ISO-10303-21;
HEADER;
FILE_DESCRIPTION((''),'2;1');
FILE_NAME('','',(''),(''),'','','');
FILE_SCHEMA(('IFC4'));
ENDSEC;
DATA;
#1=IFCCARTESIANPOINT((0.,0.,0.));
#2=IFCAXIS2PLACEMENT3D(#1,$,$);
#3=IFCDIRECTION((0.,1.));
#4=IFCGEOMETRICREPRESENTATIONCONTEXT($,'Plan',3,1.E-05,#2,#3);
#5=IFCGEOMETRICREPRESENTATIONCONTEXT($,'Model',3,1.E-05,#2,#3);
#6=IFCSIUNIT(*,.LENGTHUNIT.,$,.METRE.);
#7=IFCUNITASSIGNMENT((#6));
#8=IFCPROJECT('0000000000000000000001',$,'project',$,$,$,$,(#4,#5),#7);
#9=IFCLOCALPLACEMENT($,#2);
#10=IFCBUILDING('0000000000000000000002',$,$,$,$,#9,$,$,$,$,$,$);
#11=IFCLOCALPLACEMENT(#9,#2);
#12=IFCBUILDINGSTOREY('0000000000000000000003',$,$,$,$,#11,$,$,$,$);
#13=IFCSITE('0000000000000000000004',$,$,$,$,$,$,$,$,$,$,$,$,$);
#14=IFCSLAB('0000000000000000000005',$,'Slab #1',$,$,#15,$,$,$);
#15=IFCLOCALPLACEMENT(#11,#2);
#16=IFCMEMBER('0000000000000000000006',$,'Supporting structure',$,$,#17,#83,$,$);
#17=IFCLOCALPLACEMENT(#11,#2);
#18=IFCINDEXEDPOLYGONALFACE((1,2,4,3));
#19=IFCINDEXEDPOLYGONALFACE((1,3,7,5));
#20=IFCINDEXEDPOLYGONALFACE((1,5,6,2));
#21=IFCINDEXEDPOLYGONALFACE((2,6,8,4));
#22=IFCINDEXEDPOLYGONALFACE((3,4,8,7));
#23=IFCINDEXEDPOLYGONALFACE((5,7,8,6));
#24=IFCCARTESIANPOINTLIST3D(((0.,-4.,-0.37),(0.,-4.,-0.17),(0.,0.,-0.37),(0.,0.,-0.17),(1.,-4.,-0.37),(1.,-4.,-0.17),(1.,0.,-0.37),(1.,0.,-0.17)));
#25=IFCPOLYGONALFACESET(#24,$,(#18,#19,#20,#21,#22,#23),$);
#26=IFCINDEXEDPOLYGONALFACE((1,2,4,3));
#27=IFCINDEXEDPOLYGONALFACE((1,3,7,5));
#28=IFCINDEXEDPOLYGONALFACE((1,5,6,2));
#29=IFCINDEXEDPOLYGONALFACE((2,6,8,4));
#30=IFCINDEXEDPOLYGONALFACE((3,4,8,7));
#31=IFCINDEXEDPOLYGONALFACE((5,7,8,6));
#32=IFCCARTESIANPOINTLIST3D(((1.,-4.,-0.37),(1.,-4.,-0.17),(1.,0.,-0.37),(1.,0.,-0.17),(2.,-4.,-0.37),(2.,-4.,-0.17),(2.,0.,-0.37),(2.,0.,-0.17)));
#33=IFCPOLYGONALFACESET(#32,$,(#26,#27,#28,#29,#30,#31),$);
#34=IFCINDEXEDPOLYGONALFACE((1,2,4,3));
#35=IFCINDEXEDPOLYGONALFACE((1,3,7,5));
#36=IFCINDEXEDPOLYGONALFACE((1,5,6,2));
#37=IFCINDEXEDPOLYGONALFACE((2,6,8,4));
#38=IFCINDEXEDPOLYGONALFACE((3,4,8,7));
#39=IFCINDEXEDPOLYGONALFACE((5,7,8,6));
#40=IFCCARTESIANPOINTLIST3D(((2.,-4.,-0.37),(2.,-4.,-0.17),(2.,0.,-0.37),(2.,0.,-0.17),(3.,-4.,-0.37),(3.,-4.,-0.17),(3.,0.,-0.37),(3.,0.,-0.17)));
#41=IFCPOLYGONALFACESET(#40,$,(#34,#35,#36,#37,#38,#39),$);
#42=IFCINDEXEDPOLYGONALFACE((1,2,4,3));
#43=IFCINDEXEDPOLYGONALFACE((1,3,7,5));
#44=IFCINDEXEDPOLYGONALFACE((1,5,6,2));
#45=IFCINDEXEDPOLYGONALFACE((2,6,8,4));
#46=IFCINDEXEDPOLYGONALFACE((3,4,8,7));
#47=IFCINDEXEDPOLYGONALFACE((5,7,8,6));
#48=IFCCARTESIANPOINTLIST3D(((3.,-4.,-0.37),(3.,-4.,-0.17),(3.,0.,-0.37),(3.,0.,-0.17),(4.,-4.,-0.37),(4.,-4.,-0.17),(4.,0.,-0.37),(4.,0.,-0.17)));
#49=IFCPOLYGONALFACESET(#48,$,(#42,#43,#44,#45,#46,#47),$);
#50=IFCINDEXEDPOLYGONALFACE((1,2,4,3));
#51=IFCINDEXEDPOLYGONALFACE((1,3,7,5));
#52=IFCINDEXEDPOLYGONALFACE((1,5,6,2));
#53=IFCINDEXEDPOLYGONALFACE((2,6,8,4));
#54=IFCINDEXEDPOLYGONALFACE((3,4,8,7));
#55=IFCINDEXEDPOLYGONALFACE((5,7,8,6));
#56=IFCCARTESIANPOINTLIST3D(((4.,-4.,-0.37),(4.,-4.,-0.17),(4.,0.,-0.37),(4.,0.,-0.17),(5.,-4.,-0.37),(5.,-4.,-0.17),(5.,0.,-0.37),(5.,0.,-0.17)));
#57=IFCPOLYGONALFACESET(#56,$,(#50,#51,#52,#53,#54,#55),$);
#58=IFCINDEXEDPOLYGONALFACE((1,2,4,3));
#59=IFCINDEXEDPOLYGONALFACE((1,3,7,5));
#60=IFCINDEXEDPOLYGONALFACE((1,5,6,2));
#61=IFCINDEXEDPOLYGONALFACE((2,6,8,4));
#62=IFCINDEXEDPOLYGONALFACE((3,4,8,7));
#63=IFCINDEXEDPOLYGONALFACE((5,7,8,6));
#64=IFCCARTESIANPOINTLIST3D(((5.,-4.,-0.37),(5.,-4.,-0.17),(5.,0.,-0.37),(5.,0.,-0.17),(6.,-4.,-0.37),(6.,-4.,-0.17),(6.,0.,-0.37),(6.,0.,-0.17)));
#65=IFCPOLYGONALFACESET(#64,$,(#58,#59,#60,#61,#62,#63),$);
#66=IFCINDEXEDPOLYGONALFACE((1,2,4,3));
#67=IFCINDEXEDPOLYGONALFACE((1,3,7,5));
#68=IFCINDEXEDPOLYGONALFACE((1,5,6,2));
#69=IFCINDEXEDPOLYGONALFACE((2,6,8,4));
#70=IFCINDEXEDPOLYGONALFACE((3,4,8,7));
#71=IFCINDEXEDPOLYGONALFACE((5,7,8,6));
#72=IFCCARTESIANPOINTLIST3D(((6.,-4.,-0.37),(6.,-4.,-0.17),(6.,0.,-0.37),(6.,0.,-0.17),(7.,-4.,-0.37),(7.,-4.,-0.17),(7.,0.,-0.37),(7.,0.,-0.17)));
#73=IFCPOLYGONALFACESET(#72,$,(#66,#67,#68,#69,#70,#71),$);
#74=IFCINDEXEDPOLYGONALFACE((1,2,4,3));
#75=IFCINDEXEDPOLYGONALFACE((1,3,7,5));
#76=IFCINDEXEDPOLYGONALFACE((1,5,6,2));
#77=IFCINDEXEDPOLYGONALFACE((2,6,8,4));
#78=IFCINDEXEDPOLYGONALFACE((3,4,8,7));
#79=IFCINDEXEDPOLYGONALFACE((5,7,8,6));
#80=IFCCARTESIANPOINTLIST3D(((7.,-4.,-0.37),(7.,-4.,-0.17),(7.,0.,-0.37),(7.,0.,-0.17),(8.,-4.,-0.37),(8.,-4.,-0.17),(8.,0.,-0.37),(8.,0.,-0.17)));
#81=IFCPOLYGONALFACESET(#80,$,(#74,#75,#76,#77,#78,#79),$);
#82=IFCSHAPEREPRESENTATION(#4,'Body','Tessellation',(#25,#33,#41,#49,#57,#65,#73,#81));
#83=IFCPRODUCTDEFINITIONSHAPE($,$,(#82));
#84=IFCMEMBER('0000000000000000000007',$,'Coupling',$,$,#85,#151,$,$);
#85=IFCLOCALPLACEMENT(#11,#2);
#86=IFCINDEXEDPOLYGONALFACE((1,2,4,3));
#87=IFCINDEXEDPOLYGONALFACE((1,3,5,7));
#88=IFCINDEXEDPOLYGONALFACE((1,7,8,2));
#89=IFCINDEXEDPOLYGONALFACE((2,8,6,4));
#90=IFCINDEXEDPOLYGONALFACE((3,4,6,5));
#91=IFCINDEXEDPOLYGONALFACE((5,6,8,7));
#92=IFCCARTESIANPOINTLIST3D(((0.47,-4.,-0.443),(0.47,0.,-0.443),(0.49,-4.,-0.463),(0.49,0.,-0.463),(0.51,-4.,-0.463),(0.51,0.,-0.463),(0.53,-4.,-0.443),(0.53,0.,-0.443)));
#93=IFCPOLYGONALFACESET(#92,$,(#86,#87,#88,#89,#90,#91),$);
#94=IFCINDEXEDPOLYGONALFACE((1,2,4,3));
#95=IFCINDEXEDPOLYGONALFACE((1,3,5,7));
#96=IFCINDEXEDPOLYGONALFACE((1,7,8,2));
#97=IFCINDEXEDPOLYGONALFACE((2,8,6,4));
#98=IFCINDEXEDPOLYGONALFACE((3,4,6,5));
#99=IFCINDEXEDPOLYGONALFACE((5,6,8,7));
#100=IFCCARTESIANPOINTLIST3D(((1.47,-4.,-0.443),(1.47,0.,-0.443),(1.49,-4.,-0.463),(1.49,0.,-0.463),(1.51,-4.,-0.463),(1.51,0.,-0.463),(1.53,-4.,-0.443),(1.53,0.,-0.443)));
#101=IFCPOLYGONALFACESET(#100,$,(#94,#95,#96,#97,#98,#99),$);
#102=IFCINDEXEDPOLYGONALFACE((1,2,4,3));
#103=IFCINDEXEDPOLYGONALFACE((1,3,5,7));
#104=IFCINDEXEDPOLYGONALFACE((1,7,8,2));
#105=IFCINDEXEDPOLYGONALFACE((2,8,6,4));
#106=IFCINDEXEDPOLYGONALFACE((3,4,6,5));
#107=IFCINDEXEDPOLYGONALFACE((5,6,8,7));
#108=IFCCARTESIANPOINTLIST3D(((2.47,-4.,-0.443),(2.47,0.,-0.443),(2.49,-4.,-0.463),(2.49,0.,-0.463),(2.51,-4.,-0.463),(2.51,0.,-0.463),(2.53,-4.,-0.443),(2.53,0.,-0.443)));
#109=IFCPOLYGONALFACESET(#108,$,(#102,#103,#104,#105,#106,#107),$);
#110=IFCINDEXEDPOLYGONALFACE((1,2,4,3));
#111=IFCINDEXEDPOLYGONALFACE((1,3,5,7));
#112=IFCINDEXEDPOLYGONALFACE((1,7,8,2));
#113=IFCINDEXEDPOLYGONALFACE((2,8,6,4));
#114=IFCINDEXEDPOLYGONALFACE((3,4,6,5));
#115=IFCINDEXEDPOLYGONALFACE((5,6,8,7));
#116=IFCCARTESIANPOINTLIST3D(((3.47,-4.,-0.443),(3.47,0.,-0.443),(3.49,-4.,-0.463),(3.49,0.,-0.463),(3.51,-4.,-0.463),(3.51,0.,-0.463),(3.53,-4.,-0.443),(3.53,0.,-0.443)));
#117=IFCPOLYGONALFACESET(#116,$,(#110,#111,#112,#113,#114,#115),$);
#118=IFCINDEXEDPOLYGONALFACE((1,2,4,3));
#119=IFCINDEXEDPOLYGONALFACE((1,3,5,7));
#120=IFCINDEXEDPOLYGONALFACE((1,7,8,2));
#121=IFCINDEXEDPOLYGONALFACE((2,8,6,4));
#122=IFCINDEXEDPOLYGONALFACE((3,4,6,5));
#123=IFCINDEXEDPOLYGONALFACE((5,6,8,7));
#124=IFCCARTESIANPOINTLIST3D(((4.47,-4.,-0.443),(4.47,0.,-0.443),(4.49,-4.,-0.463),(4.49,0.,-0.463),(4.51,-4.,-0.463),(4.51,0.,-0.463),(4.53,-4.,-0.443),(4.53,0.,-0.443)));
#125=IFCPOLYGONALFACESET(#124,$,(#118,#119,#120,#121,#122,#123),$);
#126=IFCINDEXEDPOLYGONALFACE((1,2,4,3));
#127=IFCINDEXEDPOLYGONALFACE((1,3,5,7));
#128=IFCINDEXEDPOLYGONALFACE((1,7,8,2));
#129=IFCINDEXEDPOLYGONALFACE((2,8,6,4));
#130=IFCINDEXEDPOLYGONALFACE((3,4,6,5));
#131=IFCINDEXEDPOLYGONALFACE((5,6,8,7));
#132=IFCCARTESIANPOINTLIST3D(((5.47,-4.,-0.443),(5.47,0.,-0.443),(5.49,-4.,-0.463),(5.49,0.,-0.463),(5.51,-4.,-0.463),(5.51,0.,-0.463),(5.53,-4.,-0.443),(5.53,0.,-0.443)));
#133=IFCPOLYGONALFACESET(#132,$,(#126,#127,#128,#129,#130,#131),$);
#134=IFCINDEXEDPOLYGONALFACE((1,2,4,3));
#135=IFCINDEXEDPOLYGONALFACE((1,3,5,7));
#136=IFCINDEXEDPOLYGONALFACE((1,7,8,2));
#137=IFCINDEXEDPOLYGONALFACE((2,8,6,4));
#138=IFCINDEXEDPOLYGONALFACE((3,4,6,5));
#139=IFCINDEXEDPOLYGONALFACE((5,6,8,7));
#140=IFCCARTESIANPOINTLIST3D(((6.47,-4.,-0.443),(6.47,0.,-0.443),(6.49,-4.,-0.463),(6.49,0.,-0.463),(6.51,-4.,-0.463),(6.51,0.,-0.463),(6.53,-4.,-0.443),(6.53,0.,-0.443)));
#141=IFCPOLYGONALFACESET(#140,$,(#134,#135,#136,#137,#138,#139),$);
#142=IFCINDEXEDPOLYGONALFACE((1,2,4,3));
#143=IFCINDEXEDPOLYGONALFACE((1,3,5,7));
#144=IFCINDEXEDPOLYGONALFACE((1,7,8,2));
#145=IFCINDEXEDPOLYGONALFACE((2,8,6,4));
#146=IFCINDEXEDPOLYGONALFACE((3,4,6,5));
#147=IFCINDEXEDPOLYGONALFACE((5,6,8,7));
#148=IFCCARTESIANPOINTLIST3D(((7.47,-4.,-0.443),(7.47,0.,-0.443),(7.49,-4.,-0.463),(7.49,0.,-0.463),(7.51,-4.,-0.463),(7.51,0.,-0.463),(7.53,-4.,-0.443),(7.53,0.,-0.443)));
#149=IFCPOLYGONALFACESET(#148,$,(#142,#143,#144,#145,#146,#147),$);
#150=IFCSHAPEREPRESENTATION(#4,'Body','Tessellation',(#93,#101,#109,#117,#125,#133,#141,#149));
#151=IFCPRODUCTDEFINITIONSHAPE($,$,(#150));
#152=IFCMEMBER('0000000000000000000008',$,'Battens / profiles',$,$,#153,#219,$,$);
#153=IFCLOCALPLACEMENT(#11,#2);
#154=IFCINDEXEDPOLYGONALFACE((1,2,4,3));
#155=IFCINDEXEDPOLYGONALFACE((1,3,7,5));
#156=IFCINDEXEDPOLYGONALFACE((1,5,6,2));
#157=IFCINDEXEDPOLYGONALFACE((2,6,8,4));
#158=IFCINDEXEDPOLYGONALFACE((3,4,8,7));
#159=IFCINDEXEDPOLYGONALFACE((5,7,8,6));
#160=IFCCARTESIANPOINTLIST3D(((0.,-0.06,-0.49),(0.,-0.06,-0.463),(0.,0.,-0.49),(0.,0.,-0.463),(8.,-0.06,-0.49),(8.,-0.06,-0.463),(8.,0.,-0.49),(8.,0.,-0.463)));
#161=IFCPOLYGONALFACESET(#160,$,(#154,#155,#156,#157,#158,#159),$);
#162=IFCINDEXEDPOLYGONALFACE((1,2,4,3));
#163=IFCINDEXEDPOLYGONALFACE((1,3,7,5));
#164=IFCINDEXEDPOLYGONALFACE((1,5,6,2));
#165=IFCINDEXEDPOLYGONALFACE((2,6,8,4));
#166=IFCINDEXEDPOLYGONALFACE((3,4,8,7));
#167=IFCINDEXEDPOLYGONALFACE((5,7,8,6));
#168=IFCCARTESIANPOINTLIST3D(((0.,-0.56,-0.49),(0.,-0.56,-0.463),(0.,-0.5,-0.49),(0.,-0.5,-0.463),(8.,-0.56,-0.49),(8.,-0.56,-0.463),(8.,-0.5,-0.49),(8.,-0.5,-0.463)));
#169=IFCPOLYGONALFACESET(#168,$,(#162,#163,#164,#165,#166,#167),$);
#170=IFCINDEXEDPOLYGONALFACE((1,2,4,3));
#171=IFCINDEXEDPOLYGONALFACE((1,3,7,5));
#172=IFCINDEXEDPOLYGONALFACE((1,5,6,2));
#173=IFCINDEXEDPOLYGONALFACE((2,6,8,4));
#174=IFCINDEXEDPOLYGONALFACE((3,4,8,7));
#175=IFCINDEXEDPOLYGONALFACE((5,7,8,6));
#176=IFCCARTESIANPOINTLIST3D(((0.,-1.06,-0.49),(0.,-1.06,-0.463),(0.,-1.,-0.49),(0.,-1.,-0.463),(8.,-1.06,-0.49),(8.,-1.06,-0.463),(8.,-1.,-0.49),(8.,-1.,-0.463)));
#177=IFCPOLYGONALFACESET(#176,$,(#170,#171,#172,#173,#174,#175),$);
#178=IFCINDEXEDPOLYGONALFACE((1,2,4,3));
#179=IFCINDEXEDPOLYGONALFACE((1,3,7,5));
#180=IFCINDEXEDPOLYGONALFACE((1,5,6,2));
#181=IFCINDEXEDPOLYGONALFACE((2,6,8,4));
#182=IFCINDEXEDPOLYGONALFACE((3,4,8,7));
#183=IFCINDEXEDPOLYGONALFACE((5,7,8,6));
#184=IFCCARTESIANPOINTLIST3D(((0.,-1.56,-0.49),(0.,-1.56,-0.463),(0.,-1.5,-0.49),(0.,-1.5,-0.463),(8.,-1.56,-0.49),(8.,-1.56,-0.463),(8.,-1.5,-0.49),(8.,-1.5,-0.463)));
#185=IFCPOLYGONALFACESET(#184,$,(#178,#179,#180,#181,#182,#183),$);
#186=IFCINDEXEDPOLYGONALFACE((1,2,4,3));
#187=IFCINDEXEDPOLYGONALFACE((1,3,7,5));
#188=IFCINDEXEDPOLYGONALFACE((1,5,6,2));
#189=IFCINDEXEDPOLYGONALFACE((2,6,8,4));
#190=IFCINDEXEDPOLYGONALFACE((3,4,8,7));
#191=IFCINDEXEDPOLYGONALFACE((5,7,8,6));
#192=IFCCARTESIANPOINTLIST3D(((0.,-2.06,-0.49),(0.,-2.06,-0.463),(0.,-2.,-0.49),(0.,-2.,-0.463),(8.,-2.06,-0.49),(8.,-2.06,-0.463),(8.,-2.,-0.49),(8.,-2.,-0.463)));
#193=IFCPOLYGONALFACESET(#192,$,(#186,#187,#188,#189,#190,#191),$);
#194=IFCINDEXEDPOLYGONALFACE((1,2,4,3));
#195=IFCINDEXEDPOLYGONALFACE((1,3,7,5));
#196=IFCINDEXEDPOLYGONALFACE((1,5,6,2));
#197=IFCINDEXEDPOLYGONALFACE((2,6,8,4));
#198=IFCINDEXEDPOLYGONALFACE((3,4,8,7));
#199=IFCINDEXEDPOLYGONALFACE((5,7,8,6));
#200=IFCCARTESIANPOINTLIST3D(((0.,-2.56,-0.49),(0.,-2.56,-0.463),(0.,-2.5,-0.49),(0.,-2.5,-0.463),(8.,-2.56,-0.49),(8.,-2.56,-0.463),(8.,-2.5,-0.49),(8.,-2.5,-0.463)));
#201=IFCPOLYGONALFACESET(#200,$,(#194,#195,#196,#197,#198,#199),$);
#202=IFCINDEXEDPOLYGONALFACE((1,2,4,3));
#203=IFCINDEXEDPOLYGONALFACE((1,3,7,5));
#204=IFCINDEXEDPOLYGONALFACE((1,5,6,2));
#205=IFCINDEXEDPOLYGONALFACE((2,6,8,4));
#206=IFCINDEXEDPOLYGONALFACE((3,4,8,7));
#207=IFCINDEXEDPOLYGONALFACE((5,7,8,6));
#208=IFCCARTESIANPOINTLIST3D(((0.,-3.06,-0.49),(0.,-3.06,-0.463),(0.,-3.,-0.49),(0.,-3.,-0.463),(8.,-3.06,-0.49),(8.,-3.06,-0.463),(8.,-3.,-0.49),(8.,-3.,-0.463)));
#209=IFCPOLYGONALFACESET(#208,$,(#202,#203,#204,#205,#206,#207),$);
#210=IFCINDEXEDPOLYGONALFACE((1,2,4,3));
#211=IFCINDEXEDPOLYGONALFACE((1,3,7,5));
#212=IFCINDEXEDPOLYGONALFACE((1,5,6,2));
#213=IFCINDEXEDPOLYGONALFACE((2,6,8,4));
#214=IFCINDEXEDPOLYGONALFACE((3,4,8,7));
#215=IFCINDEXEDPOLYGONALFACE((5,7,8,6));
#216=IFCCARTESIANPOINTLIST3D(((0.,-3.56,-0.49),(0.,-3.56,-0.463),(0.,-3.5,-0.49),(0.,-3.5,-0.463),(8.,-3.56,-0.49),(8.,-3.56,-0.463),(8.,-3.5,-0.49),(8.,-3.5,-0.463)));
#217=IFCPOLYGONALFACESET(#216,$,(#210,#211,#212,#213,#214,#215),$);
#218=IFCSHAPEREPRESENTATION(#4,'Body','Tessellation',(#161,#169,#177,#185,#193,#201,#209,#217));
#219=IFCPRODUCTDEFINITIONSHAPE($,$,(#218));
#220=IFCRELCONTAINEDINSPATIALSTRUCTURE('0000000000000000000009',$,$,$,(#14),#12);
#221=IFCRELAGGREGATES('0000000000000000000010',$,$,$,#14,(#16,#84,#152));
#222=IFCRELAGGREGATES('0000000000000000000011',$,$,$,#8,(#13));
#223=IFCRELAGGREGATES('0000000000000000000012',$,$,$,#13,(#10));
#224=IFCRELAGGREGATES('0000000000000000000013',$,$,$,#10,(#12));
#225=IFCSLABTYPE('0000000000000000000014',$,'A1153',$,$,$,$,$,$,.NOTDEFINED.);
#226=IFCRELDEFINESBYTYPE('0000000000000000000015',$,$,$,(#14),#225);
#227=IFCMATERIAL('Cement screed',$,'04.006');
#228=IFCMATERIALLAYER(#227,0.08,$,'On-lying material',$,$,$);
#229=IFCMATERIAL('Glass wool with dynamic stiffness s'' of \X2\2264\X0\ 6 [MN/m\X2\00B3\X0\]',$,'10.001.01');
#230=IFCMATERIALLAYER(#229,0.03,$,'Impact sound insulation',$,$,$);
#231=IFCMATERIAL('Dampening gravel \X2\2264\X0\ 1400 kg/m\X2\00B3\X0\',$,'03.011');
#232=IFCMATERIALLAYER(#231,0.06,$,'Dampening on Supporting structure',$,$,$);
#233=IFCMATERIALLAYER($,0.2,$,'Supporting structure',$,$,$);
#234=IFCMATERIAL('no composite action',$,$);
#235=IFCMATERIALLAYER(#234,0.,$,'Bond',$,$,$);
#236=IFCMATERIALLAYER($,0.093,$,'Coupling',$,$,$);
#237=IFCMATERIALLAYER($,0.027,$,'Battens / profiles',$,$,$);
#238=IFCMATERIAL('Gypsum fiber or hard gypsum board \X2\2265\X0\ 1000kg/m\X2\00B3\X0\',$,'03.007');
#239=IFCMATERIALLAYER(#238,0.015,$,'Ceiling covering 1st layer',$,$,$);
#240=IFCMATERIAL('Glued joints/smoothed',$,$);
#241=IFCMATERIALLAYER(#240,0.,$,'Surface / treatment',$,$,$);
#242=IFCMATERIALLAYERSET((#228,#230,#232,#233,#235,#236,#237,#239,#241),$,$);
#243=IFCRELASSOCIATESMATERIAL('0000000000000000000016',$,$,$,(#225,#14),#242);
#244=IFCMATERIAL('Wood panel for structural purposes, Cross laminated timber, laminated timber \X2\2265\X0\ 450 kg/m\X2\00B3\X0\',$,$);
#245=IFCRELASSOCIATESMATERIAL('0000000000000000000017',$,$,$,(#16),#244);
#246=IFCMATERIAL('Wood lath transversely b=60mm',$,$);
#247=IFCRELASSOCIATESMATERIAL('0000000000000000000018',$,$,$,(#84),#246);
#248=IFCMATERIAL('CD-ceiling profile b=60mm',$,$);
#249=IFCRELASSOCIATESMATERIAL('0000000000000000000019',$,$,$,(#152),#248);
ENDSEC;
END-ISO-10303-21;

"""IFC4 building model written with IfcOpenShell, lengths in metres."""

from ifc_helpers import new_model, si_unit, direction, frame, frame_2d, origin, place, context, project, spatial, polyline, rectangle, outline, extrude, material, layer, layer_set, type_object, element, aggregate, save


model = new_model("IFC4")

# Units and contexts
plan_context = context("Plan", 3, precision=1e-05, world=origin(), true_north=direction((0.0, 1.0)))
model_context = context("Model", 3, precision=1e-05, world=origin(), true_north=direction((0.0, 1.0)))
ifc_project = project(units=[si_unit("LENGTHUNIT", "METRE")], contexts=[plan_context, model_context])

# Site, building, storey
site = spatial("IfcSite", under=ifc_project)
building_placement = place(None, origin())
building = spatial("IfcBuilding", under=site, at=building_placement)
storey_placement = place(building_placement, origin())
storey = spatial("IfcBuildingStorey", under=building, at=storey_placement)

# Slab, members
ifc_material_1 = material(Name="Cement screed", Category="04.006")
ifc_layer_1 = layer(ifc_material_1, 0.08, Name="On-lying material")
ifc_material_2 = material(Name="Glass wool with dynamic stiffness s' of ≤ 6 [MN/m³]", Category="10.001.01")
ifc_layer_2 = layer(ifc_material_2, 0.03, Name="Impact sound insulation")
ifc_material_3 = material(Name="Dampening gravel ≤ 1400 kg/m³", Category="03.011")
ifc_layer_3 = layer(ifc_material_3, 0.06, Name="Dampening on Supporting structure")
ifc_layer_4 = layer(None, 0.2, Name="Supporting structure")
ifc_material_4 = material(Name="no composite action")
ifc_layer_5 = layer(ifc_material_4, 0.0, Name="Bond")
ifc_layer_6 = layer(None, 0.093, Name="Coupling")
ifc_layer_7 = layer(None, 0.027, Name="Battens / profiles")
ifc_material_5 = material(Name="Gypsum fiber or hard gypsum board ≥ 1000kg/m³", Category="03.007")
ifc_layer_8 = layer(ifc_material_5, 0.015, Name="Ceiling covering 1st layer")
ifc_material_6 = material(Name="Glued joints/smoothed")
ifc_layer_9 = layer(ifc_material_6, 0.0, Name="Surface / treatment")
ifc_layer_set = layer_set([ifc_layer_1, ifc_layer_2, ifc_layer_3, ifc_layer_4, ifc_layer_5, ifc_layer_6, ifc_layer_7, ifc_layer_8, ifc_layer_9])
slab_type = type_object("IfcSlabType", Name="A1153", PredefinedType="NOTDEFINED", material=ifc_layer_set)
slab_placement = place(None, frame((0.0, 0.0, 0.0), z_axis=(0.0, 0.0, -1.0), x_axis=(1.0, 0.0, 0.0)))
slab = element("IfcSlab", 1, at=slab_placement, inside=storey, type_object=slab_type, material=ifc_layer_set, Name="Slab #1")
ifc_material_7 = material(Name="Wood panel for structural purposes, Cross laminated timber, laminated timber ≥ 450 kg/m³")
member_1_placement = place(slab_placement, origin())
member_1 = element("IfcMember", 2, at=member_1_placement, material=ifc_material_7, Name="Supporting structure", context=plan_context, shape_type="SweptSolid", body=[
    extrude(rectangle(XDim=1.0, YDim=0.2, at=frame_2d((0.5, 0.1), x_axis=(1.0, 0.0))), frame((0.0, 4.0, 0.17), z_axis=(0.0, -1.0, 0.0), x_axis=(1.0, 0.0, 0.0)), (0.0, 0.0, 1.0), 4.0),
    extrude(rectangle(XDim=1.0, YDim=0.2, at=frame_2d((0.5, 0.1), x_axis=(1.0, 0.0))), frame((1.0, 4.0, 0.17), z_axis=(0.0, -1.0, 0.0), x_axis=(1.0, 0.0, 0.0)), (0.0, 0.0, 1.0), 4.0),
    extrude(rectangle(XDim=1.0, YDim=0.2, at=frame_2d((0.5, 0.1), x_axis=(1.0, 0.0))), frame((2.0, 4.0, 0.17), z_axis=(0.0, -1.0, 0.0), x_axis=(1.0, 0.0, 0.0)), (0.0, 0.0, 1.0), 4.0),
    extrude(rectangle(XDim=1.0, YDim=0.2, at=frame_2d((0.5, 0.1), x_axis=(1.0, 0.0))), frame((3.0, 4.0, 0.17), z_axis=(0.0, -1.0, 0.0), x_axis=(1.0, 0.0, 0.0)), (0.0, 0.0, 1.0), 4.0),
    extrude(rectangle(XDim=1.0, YDim=0.2, at=frame_2d((0.5, 0.1), x_axis=(1.0, 0.0))), frame((4.0, 4.0, 0.17), z_axis=(0.0, -1.0, 0.0), x_axis=(1.0, 0.0, 0.0)), (0.0, 0.0, 1.0), 4.0),
    extrude(rectangle(XDim=1.0, YDim=0.2, at=frame_2d((0.5, 0.1), x_axis=(1.0, 0.0))), frame((5.0, 4.0, 0.17), z_axis=(0.0, -1.0, 0.0), x_axis=(1.0, 0.0, 0.0)), (0.0, 0.0, 1.0), 4.0),
    extrude(rectangle(XDim=1.0, YDim=0.2, at=frame_2d((0.5, 0.1), x_axis=(1.0, 0.0))), frame((6.0, 4.0, 0.17), z_axis=(0.0, -1.0, 0.0), x_axis=(1.0, 0.0, 0.0)), (0.0, 0.0, 1.0), 4.0),
    extrude(rectangle(XDim=1.0, YDim=0.2, at=frame_2d((0.5, 0.1), x_axis=(1.0, 0.0))), frame((7.0, 4.0, 0.17), z_axis=(0.0, -1.0, 0.0), x_axis=(1.0, 0.0, 0.0)), (0.0, 0.0, 1.0), 4.0),
])
ifc_material_8 = material(Name="Wood lath transversely b=60mm")
member_2_placement = place(slab_placement, origin())
member_2 = element("IfcMember", 3, at=member_2_placement, material=ifc_material_8, Name="Coupling", context=plan_context, shape_type="SweptSolid", body=[
    extrude(outline(polyline([(0.0, 0.0), (0.06, 0.0), (0.04, 0.02), (0.02, 0.02), (0.0, 0.0)])), frame((0.47, 4.0, 0.443), z_axis=(0.0, -1.0, 0.0), x_axis=(1.0, 0.0, 0.0)), (0.0, 0.0, 1.0), 4.0),
    extrude(outline(polyline([(0.0, 0.0), (0.06, 0.0), (0.04, 0.02), (0.02, 0.02), (0.0, 0.0)])), frame((1.47, 4.0, 0.443), z_axis=(0.0, -1.0, 0.0), x_axis=(1.0, 0.0, 0.0)), (0.0, 0.0, 1.0), 4.0),
    extrude(outline(polyline([(0.0, 0.0), (0.06, 0.0), (0.04, 0.02), (0.02, 0.02), (0.0, 0.0)])), frame((2.47, 4.0, 0.443), z_axis=(0.0, -1.0, 0.0), x_axis=(1.0, 0.0, 0.0)), (0.0, 0.0, 1.0), 4.0),
    extrude(outline(polyline([(0.0, 0.0), (0.06, 0.0), (0.04, 0.02), (0.02, 0.02), (0.0, 0.0)])), frame((3.47, 4.0, 0.443), z_axis=(0.0, -1.0, 0.0), x_axis=(1.0, 0.0, 0.0)), (0.0, 0.0, 1.0), 4.0),
    extrude(outline(polyline([(0.0, 0.0), (0.06, 0.0), (0.04, 0.02), (0.02, 0.02), (0.0, 0.0)])), frame((4.47, 4.0, 0.443), z_axis=(0.0, -1.0, 0.0), x_axis=(1.0, 0.0, 0.0)), (0.0, 0.0, 1.0), 4.0),
    extrude(outline(polyline([(0.0, 0.0), (0.06, 0.0), (0.04, 0.02), (0.02, 0.02), (0.0, 0.0)])), frame((5.47, 4.0, 0.443), z_axis=(0.0, -1.0, 0.0), x_axis=(1.0, 0.0, 0.0)), (0.0, 0.0, 1.0), 4.0),
    extrude(outline(polyline([(0.0, 0.0), (0.06, 0.0), (0.04, 0.02), (0.02, 0.02), (0.0, 0.0)])), frame((6.47, 4.0, 0.443), z_axis=(0.0, -1.0, 0.0), x_axis=(1.0, 0.0, 0.0)), (0.0, 0.0, 1.0), 4.0),
    extrude(outline(polyline([(0.0, 0.0), (0.06, 0.0), (0.04, 0.02), (0.02, 0.02), (0.0, 0.0)])), frame((7.47, 4.0, 0.443), z_axis=(0.0, -1.0, 0.0), x_axis=(1.0, 0.0, 0.0)), (0.0, 0.0, 1.0), 4.0),
])
ifc_material_9 = material(Name="CD-ceiling profile b=60mm")
member_3_placement = place(slab_placement, origin())
member_3 = element("IfcMember", 4, at=member_3_placement, material=ifc_material_9, Name="Battens / profiles", context=plan_context, shape_type="SweptSolid", body=[
    extrude(rectangle(XDim=0.06, YDim=0.027, at=frame_2d((0.03, 0.0135), x_axis=(1.0, 0.0))), frame((0.0, 0.0, 0.463), z_axis=(1.0, 0.0, 0.0), x_axis=(0.0, 1.0, 0.0)), (0.0, 0.0, 1.0), 8.0),
    extrude(rectangle(XDim=0.06, YDim=0.027, at=frame_2d((0.03, 0.0135), x_axis=(1.0, 0.0))), frame((0.0, 0.5, 0.463), z_axis=(1.0, 0.0, 0.0), x_axis=(0.0, 1.0, 0.0)), (0.0, 0.0, 1.0), 8.0),
    extrude(rectangle(XDim=0.06, YDim=0.027, at=frame_2d((0.03, 0.0135), x_axis=(1.0, 0.0))), frame((0.0, 1.0, 0.463), z_axis=(1.0, 0.0, 0.0), x_axis=(0.0, 1.0, 0.0)), (0.0, 0.0, 1.0), 8.0),
    extrude(rectangle(XDim=0.06, YDim=0.027, at=frame_2d((0.03, 0.0135), x_axis=(1.0, 0.0))), frame((0.0, 1.5, 0.463), z_axis=(1.0, 0.0, 0.0), x_axis=(0.0, 1.0, 0.0)), (0.0, 0.0, 1.0), 8.0),
    extrude(rectangle(XDim=0.06, YDim=0.027, at=frame_2d((0.03, 0.0135), x_axis=(1.0, 0.0))), frame((0.0, 2.0, 0.463), z_axis=(1.0, 0.0, 0.0), x_axis=(0.0, 1.0, 0.0)), (0.0, 0.0, 1.0), 8.0),
    extrude(rectangle(XDim=0.06, YDim=0.027, at=frame_2d((0.03, 0.0135), x_axis=(1.0, 0.0))), frame((0.0, 2.5, 0.463), z_axis=(1.0, 0.0, 0.0), x_axis=(0.0, 1.0, 0.0)), (0.0, 0.0, 1.0), 8.0),
    extrude(rectangle(XDim=0.06, YDim=0.027, at=frame_2d((0.03, 0.0135), x_axis=(1.0, 0.0))), frame((0.0, 3.0, 0.463), z_axis=(1.0, 0.0, 0.0), x_axis=(0.0, 1.0, 0.0)), (0.0, 0.0, 1.0), 8.0),
    extrude(rectangle(XDim=0.06, YDim=0.027, at=frame_2d((0.03, 0.0135), x_axis=(1.0, 0.0))), frame((0.0, 3.5, 0.463), z_axis=(1.0, 0.0, 0.0), x_axis=(0.0, 1.0, 0.0)), (0.0, 0.0, 1.0), 8.0),
])
aggregate(slab, [member_1, member_2, member_3])

save(model, "model.ifc")
